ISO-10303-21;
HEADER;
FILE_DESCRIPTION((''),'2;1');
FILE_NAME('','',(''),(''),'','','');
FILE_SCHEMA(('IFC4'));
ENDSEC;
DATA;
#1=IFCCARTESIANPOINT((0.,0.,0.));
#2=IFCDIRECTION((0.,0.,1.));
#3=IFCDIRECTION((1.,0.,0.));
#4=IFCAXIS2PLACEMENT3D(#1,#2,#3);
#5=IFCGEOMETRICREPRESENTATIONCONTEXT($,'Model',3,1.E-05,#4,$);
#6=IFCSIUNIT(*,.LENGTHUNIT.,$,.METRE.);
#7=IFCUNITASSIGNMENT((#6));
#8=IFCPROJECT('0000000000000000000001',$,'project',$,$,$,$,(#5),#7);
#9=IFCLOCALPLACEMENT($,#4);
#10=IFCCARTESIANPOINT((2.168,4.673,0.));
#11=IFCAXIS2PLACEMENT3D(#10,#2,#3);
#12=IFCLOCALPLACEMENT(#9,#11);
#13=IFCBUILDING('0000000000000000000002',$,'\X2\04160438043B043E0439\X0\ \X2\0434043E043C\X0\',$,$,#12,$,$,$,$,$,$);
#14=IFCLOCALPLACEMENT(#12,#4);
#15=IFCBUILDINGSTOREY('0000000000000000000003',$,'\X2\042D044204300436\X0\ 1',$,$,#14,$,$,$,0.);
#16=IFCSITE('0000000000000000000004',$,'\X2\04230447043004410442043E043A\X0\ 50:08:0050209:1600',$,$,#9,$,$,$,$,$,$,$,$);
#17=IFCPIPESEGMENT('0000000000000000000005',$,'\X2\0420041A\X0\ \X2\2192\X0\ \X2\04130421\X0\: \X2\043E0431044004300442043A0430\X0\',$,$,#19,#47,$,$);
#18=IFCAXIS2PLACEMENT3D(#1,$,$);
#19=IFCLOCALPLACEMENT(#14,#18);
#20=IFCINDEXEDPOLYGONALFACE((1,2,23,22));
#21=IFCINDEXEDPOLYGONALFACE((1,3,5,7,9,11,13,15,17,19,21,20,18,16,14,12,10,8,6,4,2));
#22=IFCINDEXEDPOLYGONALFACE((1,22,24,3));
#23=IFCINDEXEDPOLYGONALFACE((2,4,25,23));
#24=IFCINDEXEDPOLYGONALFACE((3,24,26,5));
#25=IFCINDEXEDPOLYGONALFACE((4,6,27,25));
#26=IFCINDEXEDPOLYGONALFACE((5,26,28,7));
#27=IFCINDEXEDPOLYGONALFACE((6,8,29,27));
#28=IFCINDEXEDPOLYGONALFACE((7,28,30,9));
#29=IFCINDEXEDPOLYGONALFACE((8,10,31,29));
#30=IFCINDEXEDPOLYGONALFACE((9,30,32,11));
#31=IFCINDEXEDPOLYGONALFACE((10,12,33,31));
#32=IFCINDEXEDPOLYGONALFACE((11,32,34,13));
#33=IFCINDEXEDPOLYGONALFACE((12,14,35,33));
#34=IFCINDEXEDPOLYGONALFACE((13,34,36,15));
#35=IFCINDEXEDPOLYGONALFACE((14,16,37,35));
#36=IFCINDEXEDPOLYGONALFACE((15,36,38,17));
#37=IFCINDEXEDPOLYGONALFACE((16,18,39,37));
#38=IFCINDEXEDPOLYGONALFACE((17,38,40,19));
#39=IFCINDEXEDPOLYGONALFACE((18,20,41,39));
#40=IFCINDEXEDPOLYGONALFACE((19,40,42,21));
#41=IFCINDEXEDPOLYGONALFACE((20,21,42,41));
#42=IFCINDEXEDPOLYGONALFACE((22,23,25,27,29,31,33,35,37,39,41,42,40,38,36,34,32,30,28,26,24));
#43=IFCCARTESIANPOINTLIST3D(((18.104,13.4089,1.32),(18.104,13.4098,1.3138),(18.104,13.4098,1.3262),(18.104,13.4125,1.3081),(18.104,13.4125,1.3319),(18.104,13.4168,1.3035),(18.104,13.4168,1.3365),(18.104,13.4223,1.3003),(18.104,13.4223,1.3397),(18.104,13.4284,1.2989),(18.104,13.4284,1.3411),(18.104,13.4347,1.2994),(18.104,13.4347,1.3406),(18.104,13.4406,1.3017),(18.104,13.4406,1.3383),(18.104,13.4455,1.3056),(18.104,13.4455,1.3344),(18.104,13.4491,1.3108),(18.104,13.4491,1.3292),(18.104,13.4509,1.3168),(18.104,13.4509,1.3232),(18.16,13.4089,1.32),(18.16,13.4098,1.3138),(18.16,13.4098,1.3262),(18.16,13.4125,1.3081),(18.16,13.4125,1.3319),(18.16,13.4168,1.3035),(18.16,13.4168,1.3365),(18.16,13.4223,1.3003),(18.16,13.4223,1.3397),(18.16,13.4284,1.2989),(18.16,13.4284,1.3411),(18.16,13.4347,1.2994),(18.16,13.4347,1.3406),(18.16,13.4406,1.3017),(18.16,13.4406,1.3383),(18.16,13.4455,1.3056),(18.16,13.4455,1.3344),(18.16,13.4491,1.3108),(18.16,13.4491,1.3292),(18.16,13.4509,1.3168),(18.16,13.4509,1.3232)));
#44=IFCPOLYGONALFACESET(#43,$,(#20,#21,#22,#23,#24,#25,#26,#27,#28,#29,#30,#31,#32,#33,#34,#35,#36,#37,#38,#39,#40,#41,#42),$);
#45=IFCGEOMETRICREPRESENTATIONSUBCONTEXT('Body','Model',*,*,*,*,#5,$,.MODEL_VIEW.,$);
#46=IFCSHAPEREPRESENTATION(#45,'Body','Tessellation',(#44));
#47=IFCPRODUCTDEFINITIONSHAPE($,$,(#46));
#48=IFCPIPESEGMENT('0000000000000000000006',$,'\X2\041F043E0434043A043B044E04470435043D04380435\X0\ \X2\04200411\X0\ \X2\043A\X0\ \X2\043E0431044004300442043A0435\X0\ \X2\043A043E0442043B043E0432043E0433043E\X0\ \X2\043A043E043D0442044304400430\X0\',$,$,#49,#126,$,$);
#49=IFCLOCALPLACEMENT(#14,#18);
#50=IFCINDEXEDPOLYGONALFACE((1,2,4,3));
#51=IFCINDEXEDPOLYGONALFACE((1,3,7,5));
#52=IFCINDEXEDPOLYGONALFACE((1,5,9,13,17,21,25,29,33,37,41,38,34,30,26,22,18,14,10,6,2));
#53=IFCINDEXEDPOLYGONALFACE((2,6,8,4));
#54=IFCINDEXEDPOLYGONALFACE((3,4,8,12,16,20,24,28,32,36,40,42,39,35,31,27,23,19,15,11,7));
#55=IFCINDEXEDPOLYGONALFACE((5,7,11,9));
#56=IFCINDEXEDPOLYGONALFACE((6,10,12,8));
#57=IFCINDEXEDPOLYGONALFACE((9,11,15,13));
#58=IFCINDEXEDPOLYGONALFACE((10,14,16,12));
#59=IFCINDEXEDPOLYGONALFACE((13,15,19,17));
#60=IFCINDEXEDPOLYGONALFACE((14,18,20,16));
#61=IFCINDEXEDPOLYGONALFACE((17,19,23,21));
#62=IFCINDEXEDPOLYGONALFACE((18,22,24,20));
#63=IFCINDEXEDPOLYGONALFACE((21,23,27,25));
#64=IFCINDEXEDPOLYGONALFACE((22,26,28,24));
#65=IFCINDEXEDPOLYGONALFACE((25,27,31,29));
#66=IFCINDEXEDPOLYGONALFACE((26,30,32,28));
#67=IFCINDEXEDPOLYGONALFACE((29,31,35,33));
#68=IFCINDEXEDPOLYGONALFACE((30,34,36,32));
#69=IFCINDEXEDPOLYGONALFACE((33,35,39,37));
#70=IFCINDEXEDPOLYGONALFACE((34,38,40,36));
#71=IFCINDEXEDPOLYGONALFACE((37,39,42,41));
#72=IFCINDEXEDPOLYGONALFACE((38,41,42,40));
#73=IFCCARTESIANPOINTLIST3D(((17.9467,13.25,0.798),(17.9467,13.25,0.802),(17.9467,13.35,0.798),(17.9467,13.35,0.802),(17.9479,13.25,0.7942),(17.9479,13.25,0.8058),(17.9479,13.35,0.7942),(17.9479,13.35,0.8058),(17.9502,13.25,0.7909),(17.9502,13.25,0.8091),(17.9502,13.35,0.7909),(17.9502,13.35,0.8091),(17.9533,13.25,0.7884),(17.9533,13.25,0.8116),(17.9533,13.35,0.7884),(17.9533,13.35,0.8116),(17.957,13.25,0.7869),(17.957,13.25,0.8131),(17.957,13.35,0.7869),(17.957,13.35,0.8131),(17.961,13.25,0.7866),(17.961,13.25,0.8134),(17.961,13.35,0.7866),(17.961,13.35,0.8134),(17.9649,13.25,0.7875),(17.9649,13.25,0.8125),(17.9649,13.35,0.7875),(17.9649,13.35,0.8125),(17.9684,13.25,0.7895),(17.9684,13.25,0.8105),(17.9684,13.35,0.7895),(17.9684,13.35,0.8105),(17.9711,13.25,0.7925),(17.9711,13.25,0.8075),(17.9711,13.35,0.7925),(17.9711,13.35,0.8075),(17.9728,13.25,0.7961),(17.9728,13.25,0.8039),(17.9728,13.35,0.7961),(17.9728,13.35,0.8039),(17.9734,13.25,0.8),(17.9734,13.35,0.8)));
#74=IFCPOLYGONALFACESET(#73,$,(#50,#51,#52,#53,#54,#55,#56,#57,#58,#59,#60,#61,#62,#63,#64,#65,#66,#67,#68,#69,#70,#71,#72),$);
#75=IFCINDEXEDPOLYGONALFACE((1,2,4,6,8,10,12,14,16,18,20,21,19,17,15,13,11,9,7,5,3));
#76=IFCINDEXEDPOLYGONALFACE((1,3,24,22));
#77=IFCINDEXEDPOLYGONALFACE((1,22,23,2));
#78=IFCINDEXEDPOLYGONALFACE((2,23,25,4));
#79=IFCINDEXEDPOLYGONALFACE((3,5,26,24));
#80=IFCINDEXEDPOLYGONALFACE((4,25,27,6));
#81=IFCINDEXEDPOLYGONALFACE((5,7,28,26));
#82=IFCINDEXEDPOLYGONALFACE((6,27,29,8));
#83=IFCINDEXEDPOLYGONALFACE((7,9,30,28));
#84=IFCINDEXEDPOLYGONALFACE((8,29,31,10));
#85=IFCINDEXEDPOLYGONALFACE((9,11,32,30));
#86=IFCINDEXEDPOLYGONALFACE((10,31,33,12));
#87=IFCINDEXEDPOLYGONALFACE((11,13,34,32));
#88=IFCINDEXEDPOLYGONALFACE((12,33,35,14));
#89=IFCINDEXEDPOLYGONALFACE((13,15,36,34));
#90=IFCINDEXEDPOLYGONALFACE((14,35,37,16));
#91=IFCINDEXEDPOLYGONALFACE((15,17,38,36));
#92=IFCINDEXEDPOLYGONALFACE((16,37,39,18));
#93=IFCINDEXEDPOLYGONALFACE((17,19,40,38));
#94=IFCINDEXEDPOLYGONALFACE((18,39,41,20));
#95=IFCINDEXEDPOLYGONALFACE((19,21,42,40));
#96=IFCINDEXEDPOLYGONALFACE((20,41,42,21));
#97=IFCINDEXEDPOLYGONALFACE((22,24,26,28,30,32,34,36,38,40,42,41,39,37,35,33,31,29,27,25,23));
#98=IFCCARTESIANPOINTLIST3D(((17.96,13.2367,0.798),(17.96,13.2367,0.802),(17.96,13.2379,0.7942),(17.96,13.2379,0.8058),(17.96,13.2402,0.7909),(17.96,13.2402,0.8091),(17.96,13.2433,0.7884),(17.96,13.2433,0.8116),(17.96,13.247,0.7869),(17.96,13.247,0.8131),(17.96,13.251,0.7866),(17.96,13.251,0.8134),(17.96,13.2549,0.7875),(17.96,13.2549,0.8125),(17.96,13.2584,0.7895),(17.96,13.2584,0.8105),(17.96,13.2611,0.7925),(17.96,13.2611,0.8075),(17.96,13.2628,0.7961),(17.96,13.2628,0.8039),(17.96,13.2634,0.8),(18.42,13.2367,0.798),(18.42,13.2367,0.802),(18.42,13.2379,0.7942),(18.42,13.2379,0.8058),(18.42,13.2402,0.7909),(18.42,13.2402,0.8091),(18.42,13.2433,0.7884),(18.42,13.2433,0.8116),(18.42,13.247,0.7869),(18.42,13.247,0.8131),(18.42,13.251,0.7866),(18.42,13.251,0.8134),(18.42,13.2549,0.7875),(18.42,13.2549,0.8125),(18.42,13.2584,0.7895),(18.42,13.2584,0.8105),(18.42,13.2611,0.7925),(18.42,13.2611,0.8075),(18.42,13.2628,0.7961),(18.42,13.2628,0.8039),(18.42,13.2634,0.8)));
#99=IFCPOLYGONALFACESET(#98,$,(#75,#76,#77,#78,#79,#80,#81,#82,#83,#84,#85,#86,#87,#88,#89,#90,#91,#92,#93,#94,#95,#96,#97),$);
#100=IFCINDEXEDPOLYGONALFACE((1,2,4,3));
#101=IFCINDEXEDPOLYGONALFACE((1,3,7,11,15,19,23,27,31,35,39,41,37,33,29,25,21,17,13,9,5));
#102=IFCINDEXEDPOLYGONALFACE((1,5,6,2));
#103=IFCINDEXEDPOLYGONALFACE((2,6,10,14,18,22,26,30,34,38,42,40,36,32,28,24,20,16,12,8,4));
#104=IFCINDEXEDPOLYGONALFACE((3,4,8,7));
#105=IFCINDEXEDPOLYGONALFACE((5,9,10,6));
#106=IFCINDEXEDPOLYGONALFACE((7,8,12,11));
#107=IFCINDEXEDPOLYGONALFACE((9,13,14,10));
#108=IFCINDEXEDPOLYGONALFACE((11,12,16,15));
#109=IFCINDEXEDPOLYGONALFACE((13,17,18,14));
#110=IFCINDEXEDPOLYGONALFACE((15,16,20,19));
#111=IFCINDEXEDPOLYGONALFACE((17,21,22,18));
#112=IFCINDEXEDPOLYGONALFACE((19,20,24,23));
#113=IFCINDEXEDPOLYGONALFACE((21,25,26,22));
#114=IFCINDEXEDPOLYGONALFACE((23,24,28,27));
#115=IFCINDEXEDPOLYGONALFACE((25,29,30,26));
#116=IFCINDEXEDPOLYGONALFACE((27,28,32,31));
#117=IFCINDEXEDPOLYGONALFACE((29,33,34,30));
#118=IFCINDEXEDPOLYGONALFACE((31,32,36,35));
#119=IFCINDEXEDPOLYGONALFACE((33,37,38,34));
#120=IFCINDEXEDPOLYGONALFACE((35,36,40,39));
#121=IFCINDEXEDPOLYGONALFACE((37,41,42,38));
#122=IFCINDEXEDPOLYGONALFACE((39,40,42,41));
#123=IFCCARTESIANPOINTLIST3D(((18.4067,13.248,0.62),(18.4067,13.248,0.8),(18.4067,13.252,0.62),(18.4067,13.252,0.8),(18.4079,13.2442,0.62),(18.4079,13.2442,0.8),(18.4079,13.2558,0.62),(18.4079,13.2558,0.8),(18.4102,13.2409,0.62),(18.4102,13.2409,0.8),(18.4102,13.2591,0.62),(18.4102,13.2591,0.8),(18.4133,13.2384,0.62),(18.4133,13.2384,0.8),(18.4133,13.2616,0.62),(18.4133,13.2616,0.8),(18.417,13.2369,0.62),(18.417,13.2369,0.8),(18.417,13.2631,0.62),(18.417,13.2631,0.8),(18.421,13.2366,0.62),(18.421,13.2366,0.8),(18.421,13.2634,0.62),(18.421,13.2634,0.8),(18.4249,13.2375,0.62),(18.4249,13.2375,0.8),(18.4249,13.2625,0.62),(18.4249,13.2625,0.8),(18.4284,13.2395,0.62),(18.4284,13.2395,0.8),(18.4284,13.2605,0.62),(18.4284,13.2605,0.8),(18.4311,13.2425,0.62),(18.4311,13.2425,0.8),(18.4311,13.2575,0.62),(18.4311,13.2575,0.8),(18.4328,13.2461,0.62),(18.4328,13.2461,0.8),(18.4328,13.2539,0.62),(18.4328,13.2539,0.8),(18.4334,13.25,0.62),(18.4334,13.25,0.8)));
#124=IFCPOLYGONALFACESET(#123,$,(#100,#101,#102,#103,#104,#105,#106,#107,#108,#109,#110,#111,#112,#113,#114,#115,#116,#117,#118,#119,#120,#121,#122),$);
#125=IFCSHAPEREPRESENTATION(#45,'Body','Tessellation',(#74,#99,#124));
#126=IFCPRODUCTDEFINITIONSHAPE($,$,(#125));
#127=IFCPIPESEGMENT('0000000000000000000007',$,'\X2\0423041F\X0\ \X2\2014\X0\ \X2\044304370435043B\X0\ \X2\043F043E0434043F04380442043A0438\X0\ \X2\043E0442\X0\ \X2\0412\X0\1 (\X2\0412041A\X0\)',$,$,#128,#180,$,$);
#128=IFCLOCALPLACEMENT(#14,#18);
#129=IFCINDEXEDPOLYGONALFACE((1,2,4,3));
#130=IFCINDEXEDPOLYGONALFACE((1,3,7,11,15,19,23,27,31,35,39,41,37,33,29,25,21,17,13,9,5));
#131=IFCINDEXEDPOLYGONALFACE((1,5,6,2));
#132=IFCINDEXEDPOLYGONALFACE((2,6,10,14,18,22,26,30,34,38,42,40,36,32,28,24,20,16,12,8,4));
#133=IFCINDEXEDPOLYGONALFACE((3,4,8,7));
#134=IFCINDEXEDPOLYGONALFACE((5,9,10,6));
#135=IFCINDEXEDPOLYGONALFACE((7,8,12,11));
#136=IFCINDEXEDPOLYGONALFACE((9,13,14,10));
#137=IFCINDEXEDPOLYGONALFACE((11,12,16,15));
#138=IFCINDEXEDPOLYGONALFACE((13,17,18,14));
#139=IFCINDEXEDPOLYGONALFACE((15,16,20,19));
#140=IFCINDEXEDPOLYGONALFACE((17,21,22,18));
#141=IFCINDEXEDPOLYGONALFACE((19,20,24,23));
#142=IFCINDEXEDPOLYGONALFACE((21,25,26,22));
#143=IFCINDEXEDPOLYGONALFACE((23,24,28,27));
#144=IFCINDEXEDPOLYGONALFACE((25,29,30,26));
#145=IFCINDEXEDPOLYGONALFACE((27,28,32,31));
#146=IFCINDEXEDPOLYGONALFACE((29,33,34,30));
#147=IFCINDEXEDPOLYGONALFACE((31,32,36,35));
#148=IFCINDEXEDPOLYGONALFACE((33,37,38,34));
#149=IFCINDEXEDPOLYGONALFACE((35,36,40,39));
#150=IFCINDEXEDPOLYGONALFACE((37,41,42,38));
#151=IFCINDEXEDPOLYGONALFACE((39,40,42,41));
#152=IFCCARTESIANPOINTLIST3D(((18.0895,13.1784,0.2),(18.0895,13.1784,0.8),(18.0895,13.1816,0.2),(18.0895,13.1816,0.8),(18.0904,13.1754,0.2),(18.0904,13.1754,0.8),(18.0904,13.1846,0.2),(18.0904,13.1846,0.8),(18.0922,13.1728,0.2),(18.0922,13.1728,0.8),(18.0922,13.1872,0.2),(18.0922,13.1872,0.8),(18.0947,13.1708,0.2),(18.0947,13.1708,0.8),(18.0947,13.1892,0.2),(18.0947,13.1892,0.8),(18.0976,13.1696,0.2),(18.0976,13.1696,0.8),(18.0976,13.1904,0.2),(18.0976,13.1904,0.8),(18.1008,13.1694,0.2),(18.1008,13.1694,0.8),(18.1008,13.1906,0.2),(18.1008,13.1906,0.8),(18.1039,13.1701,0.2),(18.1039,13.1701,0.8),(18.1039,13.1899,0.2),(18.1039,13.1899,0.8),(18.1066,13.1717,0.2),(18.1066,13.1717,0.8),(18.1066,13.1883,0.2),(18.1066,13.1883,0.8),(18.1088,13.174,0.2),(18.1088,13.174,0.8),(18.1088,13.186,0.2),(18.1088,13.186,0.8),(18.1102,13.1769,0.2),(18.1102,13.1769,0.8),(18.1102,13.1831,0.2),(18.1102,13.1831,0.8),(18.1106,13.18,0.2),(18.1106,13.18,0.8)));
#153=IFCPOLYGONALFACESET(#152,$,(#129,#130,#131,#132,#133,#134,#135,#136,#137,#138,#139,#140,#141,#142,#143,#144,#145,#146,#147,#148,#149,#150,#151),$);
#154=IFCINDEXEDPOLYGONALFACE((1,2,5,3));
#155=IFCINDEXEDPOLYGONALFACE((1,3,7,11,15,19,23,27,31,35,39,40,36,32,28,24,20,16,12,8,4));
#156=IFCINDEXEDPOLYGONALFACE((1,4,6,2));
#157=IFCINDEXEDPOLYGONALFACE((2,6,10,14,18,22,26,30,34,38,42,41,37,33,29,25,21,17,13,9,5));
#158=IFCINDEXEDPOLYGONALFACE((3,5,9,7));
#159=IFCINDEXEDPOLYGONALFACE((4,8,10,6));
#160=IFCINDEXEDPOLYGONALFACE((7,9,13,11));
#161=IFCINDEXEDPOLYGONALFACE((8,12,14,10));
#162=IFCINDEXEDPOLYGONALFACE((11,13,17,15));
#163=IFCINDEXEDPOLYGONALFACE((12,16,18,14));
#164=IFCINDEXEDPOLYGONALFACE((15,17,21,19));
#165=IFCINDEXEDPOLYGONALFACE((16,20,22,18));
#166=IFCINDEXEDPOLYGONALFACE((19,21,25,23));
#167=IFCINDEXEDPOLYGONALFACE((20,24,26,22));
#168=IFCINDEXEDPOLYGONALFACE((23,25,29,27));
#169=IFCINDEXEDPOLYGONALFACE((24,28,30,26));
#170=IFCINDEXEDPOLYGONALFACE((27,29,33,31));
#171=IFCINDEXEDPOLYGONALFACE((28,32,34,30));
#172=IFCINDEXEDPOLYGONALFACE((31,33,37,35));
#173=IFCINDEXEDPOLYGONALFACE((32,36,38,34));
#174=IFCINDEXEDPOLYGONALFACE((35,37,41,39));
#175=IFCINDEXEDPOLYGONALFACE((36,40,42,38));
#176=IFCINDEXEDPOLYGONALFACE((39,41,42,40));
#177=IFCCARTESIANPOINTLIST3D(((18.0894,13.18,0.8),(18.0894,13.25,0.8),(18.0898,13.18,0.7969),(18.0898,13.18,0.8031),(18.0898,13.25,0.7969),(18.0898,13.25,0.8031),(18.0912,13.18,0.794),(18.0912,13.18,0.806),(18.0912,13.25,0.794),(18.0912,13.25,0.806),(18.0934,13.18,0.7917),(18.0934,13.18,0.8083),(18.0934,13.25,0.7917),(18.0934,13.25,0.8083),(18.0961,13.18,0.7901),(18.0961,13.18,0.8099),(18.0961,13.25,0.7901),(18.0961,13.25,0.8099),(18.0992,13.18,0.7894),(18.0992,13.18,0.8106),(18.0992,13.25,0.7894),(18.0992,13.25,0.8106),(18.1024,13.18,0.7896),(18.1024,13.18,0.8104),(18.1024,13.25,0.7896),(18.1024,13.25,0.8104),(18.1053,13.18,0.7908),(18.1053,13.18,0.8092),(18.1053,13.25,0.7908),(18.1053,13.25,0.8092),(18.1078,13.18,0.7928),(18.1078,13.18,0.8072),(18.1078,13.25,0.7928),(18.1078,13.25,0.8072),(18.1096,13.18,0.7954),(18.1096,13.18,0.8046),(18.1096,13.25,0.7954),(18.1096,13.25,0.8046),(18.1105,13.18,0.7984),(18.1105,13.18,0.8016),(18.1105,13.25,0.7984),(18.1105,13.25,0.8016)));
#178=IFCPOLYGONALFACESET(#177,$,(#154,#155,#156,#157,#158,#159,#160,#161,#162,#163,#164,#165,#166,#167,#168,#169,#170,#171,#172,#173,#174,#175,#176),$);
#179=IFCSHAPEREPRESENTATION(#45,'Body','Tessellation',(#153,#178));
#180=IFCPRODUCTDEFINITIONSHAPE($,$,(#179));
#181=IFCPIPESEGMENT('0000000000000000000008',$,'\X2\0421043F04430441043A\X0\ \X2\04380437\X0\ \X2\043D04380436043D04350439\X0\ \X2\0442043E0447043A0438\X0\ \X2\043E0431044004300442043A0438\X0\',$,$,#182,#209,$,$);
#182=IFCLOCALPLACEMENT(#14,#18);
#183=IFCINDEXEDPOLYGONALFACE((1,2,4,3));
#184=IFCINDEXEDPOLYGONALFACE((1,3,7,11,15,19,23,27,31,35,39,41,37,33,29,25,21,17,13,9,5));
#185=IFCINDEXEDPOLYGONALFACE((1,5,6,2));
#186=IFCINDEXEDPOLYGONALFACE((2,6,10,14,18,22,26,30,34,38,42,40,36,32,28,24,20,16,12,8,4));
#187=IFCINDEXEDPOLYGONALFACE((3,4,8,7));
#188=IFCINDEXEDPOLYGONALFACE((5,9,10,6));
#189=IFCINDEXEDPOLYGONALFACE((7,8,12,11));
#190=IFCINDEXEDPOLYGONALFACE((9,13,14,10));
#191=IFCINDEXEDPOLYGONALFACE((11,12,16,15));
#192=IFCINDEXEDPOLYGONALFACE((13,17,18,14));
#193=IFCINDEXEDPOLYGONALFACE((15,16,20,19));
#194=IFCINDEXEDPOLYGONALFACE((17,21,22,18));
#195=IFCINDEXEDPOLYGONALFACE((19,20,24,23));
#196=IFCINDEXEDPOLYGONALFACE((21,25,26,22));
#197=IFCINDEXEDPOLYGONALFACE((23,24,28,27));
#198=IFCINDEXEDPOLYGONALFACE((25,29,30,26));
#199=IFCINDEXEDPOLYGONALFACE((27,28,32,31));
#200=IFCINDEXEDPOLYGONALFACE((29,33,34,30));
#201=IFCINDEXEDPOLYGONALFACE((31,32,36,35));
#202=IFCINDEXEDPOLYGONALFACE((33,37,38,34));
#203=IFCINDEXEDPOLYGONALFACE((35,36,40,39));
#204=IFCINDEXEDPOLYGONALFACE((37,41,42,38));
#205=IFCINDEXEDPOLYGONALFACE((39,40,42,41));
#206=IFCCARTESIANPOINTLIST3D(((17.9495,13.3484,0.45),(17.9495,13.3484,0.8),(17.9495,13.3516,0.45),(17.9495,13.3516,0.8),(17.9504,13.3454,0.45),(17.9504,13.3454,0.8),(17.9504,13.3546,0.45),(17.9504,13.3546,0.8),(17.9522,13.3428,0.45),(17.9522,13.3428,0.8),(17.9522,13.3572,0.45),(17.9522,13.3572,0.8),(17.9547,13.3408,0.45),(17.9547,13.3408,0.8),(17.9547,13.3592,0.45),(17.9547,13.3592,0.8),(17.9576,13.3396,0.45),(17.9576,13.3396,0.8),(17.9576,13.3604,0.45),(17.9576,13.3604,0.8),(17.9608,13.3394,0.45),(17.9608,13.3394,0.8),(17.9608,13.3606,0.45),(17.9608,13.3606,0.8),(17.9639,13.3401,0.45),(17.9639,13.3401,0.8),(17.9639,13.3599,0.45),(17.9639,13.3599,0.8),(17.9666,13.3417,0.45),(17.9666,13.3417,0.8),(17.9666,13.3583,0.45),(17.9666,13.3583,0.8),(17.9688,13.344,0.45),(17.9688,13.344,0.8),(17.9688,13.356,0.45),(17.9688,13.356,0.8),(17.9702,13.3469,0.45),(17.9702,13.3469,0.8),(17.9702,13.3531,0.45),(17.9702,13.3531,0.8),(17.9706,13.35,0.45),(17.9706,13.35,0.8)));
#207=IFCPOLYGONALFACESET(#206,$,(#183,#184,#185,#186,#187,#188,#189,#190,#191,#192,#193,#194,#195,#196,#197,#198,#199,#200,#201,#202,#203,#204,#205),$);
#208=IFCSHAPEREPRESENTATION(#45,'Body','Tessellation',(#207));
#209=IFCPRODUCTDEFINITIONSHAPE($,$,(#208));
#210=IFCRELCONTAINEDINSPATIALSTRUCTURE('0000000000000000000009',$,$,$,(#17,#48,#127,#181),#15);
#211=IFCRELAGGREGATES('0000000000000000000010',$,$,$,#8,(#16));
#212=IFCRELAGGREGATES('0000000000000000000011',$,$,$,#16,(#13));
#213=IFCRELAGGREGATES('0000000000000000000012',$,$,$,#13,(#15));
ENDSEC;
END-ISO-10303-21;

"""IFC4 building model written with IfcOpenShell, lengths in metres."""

from ifc_helpers import new_model, si_unit, frame, origin_with_axes, origin_2d, place, context, subcontext, project, spatial, circle, extrude, element, save


model = new_model("IFC4")

# Units and contexts
model_context = context("Model", 3, precision=1e-05, world=origin_with_axes())
body_context = subcontext(model_context, "Body", "Model", "MODEL_VIEW")
ifc_project = project(units=[si_unit("LENGTHUNIT", "METRE")], contexts=[model_context])

# Site, building, storey
site_placement = place(None, origin_with_axes())
site = spatial("IfcSite", under=ifc_project, at=site_placement, Name="Участок 50:08:0050209:1600")
building_placement = place(site_placement, frame((2.168, 4.673, 0.0), z_axis=(0.0, 0.0, 1.0), x_axis=(1.0, 0.0, 0.0)))
building = spatial("IfcBuilding", under=site, at=building_placement, Name="Жилой дом")
storey_placement = place(building_placement, origin_with_axes())
storey = spatial("IfcBuildingStorey", under=building, at=storey_placement, Name="Этаж 1", Elevation=0.0)

# Pipe segments
pipe_segment_1_placement = place(storey_placement, origin_with_axes())
element("IfcPipeSegment", 1, at=pipe_segment_1_placement, inside=storey, Name="РК → ГС: обратка", context=body_context, shape_type="SweptSolid", body=[
    extrude(circle(Radius=0.0211, at=origin_2d()), frame((18.16, 13.43, 1.32), z_axis=(-1.0, 0.0, 0.0), x_axis=(0.0, -1.0, 0.0)), (0.0, 0.0, 1.0), 0.056),
])
pipe_segment_2_placement = place(storey_placement, origin_with_axes())
element("IfcPipeSegment", 2, at=pipe_segment_2_placement, inside=storey, Name="Подключение РБ к обратке котлового контура", context=body_context, shape_type="SweptSolid", body=[
    extrude(circle(Radius=0.0134, at=origin_2d()), frame((17.96, 13.35, 0.8), z_axis=(0.0, -1.0, 0.0), x_axis=(1.0, 0.0, 0.0)), (0.0, 0.0, 1.0), 0.1),
    extrude(circle(Radius=0.0134, at=origin_2d()), frame((17.96, 13.25, 0.8), z_axis=(1.0, 0.0, 0.0), x_axis=(0.0, 1.0, 0.0)), (0.0, 0.0, 1.0), 0.46),
    extrude(circle(Radius=0.0134, at=origin_2d()), frame((18.42, 13.25, 0.8), z_axis=(0.0, 0.0, -1.0), x_axis=(1.0, 0.0, 0.0)), (0.0, 0.0, 1.0), 0.18),
])
pipe_segment_3_placement = place(storey_placement, origin_with_axes())
element("IfcPipeSegment", 3, at=pipe_segment_3_placement, inside=storey, Name="УП — узел подпитки от В1 (ВК)", context=body_context, shape_type="SweptSolid", body=[
    extrude(circle(Radius=0.0106, at=origin_2d()), frame((18.1, 13.18, 0.2), z_axis=(0.0, 0.0, 1.0), x_axis=(1.0, 0.0, 0.0)), (0.0, 0.0, 1.0), 0.6),
    extrude(circle(Radius=0.0106, at=origin_2d()), frame((18.1, 13.18, 0.8), z_axis=(0.0, 1.0, 0.0), x_axis=(-1.0, 0.0, 0.0)), (0.0, 0.0, 1.0), 0.07),
])
pipe_segment_4_placement = place(storey_placement, origin_with_axes())
element("IfcPipeSegment", 4, at=pipe_segment_4_placement, inside=storey, Name="Спуск из нижней точки обратки", context=body_context, shape_type="SweptSolid", body=[
    extrude(circle(Radius=0.0106, at=origin_2d()), frame((17.96, 13.35, 0.8), z_axis=(0.0, 0.0, -1.0), x_axis=(1.0, 0.0, 0.0)), (0.0, 0.0, 1.0), 0.35),
])

save(model, "model.ifc")
